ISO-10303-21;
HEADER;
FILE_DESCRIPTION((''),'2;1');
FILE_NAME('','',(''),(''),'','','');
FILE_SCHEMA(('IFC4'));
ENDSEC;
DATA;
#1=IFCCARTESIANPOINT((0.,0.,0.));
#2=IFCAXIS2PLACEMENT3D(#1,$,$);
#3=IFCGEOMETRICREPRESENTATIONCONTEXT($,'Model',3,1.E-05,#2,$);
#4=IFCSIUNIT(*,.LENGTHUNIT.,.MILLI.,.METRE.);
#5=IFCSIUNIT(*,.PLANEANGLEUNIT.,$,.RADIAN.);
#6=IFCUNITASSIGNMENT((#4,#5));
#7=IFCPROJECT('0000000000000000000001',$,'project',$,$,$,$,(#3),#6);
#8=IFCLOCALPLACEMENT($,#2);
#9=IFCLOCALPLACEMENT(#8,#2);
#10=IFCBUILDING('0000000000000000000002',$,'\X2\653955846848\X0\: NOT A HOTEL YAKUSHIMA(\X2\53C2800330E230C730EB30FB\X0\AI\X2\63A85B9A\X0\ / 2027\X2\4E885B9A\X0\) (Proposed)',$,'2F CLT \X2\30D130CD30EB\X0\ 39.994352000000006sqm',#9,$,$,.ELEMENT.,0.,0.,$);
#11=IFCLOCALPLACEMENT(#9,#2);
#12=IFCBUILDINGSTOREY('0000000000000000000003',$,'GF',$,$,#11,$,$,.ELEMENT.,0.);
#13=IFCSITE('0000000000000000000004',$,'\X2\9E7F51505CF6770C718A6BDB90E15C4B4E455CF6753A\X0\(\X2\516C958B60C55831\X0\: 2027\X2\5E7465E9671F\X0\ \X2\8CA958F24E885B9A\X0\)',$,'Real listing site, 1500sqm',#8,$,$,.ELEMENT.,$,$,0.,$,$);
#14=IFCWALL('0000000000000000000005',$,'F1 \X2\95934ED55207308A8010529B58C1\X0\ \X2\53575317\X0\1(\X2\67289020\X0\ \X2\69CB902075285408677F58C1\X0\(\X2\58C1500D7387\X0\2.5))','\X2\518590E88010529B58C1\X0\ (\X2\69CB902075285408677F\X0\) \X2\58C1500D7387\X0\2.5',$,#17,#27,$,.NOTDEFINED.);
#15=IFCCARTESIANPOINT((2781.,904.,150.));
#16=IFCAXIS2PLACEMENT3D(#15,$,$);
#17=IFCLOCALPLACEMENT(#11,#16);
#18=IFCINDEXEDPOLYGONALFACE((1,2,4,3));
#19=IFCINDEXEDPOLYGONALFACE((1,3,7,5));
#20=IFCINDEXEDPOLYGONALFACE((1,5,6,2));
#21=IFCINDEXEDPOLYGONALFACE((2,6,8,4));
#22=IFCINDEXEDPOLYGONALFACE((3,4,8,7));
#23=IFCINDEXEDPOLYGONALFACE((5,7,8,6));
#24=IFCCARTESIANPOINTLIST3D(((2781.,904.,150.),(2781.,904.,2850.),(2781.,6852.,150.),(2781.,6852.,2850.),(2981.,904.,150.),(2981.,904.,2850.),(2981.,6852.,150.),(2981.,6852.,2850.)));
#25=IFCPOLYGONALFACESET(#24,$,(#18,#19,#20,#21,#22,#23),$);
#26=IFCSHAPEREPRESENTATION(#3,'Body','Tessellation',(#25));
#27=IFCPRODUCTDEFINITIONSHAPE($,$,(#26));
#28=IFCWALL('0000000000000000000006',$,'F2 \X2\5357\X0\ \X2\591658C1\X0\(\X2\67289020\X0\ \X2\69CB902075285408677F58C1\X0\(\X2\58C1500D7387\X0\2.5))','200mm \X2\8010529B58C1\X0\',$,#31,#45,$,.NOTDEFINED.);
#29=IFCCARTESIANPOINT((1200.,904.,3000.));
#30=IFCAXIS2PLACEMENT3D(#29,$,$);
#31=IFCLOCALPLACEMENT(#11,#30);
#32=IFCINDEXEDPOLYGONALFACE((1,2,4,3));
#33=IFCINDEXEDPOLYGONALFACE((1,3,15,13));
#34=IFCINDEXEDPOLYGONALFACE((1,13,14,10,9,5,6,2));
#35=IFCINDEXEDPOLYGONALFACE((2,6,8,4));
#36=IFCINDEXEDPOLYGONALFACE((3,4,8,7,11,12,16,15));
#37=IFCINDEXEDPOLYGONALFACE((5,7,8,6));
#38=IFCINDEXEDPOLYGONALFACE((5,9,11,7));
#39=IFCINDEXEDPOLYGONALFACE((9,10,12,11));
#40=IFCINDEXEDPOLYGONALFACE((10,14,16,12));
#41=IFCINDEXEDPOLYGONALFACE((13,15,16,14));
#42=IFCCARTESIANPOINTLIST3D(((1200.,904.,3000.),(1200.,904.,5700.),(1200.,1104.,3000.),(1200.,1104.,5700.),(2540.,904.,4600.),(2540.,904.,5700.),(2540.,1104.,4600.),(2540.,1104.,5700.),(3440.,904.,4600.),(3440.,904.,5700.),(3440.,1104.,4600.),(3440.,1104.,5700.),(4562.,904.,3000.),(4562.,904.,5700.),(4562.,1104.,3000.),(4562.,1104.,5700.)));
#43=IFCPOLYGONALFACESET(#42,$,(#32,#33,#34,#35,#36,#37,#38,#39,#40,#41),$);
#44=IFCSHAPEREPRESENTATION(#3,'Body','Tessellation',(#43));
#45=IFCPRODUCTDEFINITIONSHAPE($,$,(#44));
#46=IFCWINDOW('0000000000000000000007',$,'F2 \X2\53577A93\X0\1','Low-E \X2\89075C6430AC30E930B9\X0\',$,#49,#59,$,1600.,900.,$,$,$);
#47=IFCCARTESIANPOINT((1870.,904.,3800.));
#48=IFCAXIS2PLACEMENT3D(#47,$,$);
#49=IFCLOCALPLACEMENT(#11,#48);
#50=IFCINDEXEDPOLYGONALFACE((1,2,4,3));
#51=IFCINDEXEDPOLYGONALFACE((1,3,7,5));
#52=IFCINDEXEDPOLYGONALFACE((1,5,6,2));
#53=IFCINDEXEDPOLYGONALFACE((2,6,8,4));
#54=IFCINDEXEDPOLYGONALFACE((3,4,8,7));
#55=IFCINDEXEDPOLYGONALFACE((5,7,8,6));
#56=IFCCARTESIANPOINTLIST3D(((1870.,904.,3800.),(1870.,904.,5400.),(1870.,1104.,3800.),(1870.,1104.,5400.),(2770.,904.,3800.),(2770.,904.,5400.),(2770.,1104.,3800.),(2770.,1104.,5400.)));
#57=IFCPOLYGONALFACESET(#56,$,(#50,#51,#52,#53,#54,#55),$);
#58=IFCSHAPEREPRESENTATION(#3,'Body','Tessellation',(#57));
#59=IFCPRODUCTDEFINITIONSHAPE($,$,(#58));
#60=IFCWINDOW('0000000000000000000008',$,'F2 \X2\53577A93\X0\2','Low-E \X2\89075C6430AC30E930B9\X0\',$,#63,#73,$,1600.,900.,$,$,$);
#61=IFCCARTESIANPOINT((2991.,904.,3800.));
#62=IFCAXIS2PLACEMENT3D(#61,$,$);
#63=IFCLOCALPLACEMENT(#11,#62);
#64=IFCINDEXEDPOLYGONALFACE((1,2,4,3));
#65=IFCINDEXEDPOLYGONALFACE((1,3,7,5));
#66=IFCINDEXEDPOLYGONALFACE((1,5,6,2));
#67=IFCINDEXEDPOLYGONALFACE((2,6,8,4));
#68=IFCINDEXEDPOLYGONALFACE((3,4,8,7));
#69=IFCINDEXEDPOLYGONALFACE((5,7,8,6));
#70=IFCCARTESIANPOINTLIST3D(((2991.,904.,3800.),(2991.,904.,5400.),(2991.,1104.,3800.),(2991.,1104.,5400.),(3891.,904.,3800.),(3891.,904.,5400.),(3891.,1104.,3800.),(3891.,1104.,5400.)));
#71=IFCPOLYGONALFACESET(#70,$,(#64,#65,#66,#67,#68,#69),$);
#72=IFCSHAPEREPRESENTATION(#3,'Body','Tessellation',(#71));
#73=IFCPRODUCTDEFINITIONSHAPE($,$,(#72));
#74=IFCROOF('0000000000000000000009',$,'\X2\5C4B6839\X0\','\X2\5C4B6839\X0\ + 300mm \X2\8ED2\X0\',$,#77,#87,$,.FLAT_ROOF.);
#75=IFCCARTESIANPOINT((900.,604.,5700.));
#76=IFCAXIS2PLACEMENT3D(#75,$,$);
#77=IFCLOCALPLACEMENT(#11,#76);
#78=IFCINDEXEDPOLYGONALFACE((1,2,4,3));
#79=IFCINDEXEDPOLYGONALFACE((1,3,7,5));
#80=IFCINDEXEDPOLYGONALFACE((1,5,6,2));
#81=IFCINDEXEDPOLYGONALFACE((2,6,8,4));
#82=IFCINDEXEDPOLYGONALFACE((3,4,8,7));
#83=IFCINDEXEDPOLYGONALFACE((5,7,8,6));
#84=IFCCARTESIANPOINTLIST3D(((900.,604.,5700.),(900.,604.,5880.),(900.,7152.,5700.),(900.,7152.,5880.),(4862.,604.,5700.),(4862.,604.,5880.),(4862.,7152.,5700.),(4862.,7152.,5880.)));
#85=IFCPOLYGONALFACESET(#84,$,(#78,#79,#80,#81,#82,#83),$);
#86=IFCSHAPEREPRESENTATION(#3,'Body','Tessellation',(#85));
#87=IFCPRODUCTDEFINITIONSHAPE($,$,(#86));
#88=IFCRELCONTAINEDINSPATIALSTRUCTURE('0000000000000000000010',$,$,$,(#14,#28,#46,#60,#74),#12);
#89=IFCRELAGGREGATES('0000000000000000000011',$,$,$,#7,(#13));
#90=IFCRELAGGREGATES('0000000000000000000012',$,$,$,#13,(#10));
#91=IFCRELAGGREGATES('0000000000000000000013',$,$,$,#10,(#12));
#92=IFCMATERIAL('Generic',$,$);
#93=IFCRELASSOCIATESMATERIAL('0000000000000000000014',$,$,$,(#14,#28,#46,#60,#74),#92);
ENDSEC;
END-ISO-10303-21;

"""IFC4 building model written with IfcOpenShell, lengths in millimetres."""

from ifc_helpers import new_model, si_unit, frame, frame_2d, origin, place, context, project, spatial, rectangle, extrude, material, element, fill, save


model = new_model("IFC4")

# Units and contexts
model_context = context("Model", 3, precision=1e-05, world=origin())
ifc_project = project(units=[si_unit("LENGTHUNIT", "METRE", prefix="MILLI"), si_unit("PLANEANGLEUNIT", "RADIAN")], contexts=[model_context])

# Site, building, storey
site_placement = place(None, origin())
site = spatial("IfcSite", under=ifc_project, at=site_placement, Name="鹿児島県熊毛郡屋久島町(公開情報: 2027年早期 販売予定)", ObjectType="Real listing site, 1500sqm", CompositionType="ELEMENT", RefElevation=0.0)
building_placement = place(site_placement, origin())
building = spatial("IfcBuilding", under=site, at=building_placement, Name="改善案: NOT A HOTEL YAKUSHIMA(参考モデル・AI推定 / 2027予定) (Proposed)", ObjectType="2F CLT パネル 39.994352000000006sqm", CompositionType="ELEMENT", ElevationOfRefHeight=0.0, ElevationOfTerrain=0.0)
storey_placement = place(building_placement, origin())
storey = spatial("IfcBuildingStorey", under=building, at=storey_placement, Name="GF", CompositionType="ELEMENT", Elevation=0.0)

# Shared definitions
ifc_material_1 = material(Name="Generic")

# Wall
wall_1_placement = place(storey_placement, frame((2781.0, 904.0, 150.0)))
element("IfcWall", 1, at=wall_1_placement, inside=storey, material=ifc_material_1, Name="F1 間仕切り耐力壁 南北1(木造 構造用合板壁(壁倍率2.5))", Description="内部耐力壁 (構造用合板) 壁倍率2.5", PredefinedType="NOTDEFINED", context=model_context, shape_type="SweptSolid", body=[
    extrude(rectangle(XDim=200.0, YDim=5948.0, at=frame_2d((100.0, 2974.0))), frame((2781.0, 904.0, 150.0)), (0.0, 0.0, 1.0), 2700.0),
])

# Wall, openings, windows
wall_2_placement = place(storey_placement, frame((1200.0, 904.0, 3000.0)))
wall_2 = element("IfcWall", 2, at=wall_2_placement, inside=storey, material=ifc_material_1, Name="F2 南 外壁(木造 構造用合板壁(壁倍率2.5))", Description="200mm 耐力壁", PredefinedType="NOTDEFINED", context=model_context, shape_type="SweptSolid", body=[
    extrude(rectangle(XDim=3362.0, YDim=200.0, at=frame_2d((1681.0, 100.0))), frame((1200.0, 904.0, 3000.0)), (0.0, 0.0, 1.0), 2700.0),
])
opening_1_placement = place(storey_placement, frame((1870.0, 904.0, 3800.0)))
opening_1 = element("IfcOpeningElement", 3, at=opening_1_placement, cuts=wall_2, PredefinedType="NOTDEFINED", context=model_context, shape_type="SweptSolid", body=[
    extrude(rectangle(XDim=900.0, YDim=200.0, at=frame_2d((450.0, 100.0))), frame((1870.0, 904.0, 3800.0)), (0.0, 0.0, 1.0), 1600.0),
])
opening_2_placement = place(storey_placement, frame((2991.0, 904.0, 3800.0)))
opening_2 = element("IfcOpeningElement", 4, at=opening_2_placement, cuts=wall_2, PredefinedType="NOTDEFINED", context=model_context, shape_type="SweptSolid", body=[
    extrude(rectangle(XDim=900.0, YDim=200.0, at=frame_2d((450.0, 100.0))), frame((2991.0, 904.0, 3800.0)), (0.0, 0.0, 1.0), 1600.0),
])
window_1_placement = place(storey_placement, frame((1870.0, 904.0, 3800.0)))
window_1 = element("IfcWindow", 5, at=window_1_placement, inside=storey, material=ifc_material_1, Name="F2 南窓1", Description="Low-E 複層ガラス", OverallHeight=1600.0, OverallWidth=900.0, context=model_context, shape_type="SweptSolid", body=[
    extrude(rectangle(XDim=900.0, YDim=200.0, at=frame_2d((450.0, 100.0))), frame((1870.0, 904.0, 3800.0)), (0.0, 0.0, 1.0), 1600.0),
])
fill(opening_1, window_1)
window_2_placement = place(storey_placement, frame((2991.0, 904.0, 3800.0)))
window_2 = element("IfcWindow", 6, at=window_2_placement, inside=storey, material=ifc_material_1, Name="F2 南窓2", Description="Low-E 複層ガラス", OverallHeight=1600.0, OverallWidth=900.0, context=model_context, shape_type="SweptSolid", body=[
    extrude(rectangle(XDim=900.0, YDim=200.0, at=frame_2d((450.0, 100.0))), frame((2991.0, 904.0, 3800.0)), (0.0, 0.0, 1.0), 1600.0),
])
fill(opening_2, window_2)

# Roof
roof_placement = place(storey_placement, frame((900.0, 604.0, 5700.0)))
element("IfcRoof", 7, at=roof_placement, inside=storey, material=ifc_material_1, Name="屋根", Description="屋根 + 300mm 軒", PredefinedType="FLAT_ROOF", context=model_context, shape_type="SweptSolid", body=[
    extrude(rectangle(XDim=3962.0, YDim=6548.0, at=frame_2d((1981.0, 3274.0))), frame((900.0, 604.0, 5700.0)), (0.0, 0.0, 1.0), 180.0),
])

save(model, "model.ifc")
